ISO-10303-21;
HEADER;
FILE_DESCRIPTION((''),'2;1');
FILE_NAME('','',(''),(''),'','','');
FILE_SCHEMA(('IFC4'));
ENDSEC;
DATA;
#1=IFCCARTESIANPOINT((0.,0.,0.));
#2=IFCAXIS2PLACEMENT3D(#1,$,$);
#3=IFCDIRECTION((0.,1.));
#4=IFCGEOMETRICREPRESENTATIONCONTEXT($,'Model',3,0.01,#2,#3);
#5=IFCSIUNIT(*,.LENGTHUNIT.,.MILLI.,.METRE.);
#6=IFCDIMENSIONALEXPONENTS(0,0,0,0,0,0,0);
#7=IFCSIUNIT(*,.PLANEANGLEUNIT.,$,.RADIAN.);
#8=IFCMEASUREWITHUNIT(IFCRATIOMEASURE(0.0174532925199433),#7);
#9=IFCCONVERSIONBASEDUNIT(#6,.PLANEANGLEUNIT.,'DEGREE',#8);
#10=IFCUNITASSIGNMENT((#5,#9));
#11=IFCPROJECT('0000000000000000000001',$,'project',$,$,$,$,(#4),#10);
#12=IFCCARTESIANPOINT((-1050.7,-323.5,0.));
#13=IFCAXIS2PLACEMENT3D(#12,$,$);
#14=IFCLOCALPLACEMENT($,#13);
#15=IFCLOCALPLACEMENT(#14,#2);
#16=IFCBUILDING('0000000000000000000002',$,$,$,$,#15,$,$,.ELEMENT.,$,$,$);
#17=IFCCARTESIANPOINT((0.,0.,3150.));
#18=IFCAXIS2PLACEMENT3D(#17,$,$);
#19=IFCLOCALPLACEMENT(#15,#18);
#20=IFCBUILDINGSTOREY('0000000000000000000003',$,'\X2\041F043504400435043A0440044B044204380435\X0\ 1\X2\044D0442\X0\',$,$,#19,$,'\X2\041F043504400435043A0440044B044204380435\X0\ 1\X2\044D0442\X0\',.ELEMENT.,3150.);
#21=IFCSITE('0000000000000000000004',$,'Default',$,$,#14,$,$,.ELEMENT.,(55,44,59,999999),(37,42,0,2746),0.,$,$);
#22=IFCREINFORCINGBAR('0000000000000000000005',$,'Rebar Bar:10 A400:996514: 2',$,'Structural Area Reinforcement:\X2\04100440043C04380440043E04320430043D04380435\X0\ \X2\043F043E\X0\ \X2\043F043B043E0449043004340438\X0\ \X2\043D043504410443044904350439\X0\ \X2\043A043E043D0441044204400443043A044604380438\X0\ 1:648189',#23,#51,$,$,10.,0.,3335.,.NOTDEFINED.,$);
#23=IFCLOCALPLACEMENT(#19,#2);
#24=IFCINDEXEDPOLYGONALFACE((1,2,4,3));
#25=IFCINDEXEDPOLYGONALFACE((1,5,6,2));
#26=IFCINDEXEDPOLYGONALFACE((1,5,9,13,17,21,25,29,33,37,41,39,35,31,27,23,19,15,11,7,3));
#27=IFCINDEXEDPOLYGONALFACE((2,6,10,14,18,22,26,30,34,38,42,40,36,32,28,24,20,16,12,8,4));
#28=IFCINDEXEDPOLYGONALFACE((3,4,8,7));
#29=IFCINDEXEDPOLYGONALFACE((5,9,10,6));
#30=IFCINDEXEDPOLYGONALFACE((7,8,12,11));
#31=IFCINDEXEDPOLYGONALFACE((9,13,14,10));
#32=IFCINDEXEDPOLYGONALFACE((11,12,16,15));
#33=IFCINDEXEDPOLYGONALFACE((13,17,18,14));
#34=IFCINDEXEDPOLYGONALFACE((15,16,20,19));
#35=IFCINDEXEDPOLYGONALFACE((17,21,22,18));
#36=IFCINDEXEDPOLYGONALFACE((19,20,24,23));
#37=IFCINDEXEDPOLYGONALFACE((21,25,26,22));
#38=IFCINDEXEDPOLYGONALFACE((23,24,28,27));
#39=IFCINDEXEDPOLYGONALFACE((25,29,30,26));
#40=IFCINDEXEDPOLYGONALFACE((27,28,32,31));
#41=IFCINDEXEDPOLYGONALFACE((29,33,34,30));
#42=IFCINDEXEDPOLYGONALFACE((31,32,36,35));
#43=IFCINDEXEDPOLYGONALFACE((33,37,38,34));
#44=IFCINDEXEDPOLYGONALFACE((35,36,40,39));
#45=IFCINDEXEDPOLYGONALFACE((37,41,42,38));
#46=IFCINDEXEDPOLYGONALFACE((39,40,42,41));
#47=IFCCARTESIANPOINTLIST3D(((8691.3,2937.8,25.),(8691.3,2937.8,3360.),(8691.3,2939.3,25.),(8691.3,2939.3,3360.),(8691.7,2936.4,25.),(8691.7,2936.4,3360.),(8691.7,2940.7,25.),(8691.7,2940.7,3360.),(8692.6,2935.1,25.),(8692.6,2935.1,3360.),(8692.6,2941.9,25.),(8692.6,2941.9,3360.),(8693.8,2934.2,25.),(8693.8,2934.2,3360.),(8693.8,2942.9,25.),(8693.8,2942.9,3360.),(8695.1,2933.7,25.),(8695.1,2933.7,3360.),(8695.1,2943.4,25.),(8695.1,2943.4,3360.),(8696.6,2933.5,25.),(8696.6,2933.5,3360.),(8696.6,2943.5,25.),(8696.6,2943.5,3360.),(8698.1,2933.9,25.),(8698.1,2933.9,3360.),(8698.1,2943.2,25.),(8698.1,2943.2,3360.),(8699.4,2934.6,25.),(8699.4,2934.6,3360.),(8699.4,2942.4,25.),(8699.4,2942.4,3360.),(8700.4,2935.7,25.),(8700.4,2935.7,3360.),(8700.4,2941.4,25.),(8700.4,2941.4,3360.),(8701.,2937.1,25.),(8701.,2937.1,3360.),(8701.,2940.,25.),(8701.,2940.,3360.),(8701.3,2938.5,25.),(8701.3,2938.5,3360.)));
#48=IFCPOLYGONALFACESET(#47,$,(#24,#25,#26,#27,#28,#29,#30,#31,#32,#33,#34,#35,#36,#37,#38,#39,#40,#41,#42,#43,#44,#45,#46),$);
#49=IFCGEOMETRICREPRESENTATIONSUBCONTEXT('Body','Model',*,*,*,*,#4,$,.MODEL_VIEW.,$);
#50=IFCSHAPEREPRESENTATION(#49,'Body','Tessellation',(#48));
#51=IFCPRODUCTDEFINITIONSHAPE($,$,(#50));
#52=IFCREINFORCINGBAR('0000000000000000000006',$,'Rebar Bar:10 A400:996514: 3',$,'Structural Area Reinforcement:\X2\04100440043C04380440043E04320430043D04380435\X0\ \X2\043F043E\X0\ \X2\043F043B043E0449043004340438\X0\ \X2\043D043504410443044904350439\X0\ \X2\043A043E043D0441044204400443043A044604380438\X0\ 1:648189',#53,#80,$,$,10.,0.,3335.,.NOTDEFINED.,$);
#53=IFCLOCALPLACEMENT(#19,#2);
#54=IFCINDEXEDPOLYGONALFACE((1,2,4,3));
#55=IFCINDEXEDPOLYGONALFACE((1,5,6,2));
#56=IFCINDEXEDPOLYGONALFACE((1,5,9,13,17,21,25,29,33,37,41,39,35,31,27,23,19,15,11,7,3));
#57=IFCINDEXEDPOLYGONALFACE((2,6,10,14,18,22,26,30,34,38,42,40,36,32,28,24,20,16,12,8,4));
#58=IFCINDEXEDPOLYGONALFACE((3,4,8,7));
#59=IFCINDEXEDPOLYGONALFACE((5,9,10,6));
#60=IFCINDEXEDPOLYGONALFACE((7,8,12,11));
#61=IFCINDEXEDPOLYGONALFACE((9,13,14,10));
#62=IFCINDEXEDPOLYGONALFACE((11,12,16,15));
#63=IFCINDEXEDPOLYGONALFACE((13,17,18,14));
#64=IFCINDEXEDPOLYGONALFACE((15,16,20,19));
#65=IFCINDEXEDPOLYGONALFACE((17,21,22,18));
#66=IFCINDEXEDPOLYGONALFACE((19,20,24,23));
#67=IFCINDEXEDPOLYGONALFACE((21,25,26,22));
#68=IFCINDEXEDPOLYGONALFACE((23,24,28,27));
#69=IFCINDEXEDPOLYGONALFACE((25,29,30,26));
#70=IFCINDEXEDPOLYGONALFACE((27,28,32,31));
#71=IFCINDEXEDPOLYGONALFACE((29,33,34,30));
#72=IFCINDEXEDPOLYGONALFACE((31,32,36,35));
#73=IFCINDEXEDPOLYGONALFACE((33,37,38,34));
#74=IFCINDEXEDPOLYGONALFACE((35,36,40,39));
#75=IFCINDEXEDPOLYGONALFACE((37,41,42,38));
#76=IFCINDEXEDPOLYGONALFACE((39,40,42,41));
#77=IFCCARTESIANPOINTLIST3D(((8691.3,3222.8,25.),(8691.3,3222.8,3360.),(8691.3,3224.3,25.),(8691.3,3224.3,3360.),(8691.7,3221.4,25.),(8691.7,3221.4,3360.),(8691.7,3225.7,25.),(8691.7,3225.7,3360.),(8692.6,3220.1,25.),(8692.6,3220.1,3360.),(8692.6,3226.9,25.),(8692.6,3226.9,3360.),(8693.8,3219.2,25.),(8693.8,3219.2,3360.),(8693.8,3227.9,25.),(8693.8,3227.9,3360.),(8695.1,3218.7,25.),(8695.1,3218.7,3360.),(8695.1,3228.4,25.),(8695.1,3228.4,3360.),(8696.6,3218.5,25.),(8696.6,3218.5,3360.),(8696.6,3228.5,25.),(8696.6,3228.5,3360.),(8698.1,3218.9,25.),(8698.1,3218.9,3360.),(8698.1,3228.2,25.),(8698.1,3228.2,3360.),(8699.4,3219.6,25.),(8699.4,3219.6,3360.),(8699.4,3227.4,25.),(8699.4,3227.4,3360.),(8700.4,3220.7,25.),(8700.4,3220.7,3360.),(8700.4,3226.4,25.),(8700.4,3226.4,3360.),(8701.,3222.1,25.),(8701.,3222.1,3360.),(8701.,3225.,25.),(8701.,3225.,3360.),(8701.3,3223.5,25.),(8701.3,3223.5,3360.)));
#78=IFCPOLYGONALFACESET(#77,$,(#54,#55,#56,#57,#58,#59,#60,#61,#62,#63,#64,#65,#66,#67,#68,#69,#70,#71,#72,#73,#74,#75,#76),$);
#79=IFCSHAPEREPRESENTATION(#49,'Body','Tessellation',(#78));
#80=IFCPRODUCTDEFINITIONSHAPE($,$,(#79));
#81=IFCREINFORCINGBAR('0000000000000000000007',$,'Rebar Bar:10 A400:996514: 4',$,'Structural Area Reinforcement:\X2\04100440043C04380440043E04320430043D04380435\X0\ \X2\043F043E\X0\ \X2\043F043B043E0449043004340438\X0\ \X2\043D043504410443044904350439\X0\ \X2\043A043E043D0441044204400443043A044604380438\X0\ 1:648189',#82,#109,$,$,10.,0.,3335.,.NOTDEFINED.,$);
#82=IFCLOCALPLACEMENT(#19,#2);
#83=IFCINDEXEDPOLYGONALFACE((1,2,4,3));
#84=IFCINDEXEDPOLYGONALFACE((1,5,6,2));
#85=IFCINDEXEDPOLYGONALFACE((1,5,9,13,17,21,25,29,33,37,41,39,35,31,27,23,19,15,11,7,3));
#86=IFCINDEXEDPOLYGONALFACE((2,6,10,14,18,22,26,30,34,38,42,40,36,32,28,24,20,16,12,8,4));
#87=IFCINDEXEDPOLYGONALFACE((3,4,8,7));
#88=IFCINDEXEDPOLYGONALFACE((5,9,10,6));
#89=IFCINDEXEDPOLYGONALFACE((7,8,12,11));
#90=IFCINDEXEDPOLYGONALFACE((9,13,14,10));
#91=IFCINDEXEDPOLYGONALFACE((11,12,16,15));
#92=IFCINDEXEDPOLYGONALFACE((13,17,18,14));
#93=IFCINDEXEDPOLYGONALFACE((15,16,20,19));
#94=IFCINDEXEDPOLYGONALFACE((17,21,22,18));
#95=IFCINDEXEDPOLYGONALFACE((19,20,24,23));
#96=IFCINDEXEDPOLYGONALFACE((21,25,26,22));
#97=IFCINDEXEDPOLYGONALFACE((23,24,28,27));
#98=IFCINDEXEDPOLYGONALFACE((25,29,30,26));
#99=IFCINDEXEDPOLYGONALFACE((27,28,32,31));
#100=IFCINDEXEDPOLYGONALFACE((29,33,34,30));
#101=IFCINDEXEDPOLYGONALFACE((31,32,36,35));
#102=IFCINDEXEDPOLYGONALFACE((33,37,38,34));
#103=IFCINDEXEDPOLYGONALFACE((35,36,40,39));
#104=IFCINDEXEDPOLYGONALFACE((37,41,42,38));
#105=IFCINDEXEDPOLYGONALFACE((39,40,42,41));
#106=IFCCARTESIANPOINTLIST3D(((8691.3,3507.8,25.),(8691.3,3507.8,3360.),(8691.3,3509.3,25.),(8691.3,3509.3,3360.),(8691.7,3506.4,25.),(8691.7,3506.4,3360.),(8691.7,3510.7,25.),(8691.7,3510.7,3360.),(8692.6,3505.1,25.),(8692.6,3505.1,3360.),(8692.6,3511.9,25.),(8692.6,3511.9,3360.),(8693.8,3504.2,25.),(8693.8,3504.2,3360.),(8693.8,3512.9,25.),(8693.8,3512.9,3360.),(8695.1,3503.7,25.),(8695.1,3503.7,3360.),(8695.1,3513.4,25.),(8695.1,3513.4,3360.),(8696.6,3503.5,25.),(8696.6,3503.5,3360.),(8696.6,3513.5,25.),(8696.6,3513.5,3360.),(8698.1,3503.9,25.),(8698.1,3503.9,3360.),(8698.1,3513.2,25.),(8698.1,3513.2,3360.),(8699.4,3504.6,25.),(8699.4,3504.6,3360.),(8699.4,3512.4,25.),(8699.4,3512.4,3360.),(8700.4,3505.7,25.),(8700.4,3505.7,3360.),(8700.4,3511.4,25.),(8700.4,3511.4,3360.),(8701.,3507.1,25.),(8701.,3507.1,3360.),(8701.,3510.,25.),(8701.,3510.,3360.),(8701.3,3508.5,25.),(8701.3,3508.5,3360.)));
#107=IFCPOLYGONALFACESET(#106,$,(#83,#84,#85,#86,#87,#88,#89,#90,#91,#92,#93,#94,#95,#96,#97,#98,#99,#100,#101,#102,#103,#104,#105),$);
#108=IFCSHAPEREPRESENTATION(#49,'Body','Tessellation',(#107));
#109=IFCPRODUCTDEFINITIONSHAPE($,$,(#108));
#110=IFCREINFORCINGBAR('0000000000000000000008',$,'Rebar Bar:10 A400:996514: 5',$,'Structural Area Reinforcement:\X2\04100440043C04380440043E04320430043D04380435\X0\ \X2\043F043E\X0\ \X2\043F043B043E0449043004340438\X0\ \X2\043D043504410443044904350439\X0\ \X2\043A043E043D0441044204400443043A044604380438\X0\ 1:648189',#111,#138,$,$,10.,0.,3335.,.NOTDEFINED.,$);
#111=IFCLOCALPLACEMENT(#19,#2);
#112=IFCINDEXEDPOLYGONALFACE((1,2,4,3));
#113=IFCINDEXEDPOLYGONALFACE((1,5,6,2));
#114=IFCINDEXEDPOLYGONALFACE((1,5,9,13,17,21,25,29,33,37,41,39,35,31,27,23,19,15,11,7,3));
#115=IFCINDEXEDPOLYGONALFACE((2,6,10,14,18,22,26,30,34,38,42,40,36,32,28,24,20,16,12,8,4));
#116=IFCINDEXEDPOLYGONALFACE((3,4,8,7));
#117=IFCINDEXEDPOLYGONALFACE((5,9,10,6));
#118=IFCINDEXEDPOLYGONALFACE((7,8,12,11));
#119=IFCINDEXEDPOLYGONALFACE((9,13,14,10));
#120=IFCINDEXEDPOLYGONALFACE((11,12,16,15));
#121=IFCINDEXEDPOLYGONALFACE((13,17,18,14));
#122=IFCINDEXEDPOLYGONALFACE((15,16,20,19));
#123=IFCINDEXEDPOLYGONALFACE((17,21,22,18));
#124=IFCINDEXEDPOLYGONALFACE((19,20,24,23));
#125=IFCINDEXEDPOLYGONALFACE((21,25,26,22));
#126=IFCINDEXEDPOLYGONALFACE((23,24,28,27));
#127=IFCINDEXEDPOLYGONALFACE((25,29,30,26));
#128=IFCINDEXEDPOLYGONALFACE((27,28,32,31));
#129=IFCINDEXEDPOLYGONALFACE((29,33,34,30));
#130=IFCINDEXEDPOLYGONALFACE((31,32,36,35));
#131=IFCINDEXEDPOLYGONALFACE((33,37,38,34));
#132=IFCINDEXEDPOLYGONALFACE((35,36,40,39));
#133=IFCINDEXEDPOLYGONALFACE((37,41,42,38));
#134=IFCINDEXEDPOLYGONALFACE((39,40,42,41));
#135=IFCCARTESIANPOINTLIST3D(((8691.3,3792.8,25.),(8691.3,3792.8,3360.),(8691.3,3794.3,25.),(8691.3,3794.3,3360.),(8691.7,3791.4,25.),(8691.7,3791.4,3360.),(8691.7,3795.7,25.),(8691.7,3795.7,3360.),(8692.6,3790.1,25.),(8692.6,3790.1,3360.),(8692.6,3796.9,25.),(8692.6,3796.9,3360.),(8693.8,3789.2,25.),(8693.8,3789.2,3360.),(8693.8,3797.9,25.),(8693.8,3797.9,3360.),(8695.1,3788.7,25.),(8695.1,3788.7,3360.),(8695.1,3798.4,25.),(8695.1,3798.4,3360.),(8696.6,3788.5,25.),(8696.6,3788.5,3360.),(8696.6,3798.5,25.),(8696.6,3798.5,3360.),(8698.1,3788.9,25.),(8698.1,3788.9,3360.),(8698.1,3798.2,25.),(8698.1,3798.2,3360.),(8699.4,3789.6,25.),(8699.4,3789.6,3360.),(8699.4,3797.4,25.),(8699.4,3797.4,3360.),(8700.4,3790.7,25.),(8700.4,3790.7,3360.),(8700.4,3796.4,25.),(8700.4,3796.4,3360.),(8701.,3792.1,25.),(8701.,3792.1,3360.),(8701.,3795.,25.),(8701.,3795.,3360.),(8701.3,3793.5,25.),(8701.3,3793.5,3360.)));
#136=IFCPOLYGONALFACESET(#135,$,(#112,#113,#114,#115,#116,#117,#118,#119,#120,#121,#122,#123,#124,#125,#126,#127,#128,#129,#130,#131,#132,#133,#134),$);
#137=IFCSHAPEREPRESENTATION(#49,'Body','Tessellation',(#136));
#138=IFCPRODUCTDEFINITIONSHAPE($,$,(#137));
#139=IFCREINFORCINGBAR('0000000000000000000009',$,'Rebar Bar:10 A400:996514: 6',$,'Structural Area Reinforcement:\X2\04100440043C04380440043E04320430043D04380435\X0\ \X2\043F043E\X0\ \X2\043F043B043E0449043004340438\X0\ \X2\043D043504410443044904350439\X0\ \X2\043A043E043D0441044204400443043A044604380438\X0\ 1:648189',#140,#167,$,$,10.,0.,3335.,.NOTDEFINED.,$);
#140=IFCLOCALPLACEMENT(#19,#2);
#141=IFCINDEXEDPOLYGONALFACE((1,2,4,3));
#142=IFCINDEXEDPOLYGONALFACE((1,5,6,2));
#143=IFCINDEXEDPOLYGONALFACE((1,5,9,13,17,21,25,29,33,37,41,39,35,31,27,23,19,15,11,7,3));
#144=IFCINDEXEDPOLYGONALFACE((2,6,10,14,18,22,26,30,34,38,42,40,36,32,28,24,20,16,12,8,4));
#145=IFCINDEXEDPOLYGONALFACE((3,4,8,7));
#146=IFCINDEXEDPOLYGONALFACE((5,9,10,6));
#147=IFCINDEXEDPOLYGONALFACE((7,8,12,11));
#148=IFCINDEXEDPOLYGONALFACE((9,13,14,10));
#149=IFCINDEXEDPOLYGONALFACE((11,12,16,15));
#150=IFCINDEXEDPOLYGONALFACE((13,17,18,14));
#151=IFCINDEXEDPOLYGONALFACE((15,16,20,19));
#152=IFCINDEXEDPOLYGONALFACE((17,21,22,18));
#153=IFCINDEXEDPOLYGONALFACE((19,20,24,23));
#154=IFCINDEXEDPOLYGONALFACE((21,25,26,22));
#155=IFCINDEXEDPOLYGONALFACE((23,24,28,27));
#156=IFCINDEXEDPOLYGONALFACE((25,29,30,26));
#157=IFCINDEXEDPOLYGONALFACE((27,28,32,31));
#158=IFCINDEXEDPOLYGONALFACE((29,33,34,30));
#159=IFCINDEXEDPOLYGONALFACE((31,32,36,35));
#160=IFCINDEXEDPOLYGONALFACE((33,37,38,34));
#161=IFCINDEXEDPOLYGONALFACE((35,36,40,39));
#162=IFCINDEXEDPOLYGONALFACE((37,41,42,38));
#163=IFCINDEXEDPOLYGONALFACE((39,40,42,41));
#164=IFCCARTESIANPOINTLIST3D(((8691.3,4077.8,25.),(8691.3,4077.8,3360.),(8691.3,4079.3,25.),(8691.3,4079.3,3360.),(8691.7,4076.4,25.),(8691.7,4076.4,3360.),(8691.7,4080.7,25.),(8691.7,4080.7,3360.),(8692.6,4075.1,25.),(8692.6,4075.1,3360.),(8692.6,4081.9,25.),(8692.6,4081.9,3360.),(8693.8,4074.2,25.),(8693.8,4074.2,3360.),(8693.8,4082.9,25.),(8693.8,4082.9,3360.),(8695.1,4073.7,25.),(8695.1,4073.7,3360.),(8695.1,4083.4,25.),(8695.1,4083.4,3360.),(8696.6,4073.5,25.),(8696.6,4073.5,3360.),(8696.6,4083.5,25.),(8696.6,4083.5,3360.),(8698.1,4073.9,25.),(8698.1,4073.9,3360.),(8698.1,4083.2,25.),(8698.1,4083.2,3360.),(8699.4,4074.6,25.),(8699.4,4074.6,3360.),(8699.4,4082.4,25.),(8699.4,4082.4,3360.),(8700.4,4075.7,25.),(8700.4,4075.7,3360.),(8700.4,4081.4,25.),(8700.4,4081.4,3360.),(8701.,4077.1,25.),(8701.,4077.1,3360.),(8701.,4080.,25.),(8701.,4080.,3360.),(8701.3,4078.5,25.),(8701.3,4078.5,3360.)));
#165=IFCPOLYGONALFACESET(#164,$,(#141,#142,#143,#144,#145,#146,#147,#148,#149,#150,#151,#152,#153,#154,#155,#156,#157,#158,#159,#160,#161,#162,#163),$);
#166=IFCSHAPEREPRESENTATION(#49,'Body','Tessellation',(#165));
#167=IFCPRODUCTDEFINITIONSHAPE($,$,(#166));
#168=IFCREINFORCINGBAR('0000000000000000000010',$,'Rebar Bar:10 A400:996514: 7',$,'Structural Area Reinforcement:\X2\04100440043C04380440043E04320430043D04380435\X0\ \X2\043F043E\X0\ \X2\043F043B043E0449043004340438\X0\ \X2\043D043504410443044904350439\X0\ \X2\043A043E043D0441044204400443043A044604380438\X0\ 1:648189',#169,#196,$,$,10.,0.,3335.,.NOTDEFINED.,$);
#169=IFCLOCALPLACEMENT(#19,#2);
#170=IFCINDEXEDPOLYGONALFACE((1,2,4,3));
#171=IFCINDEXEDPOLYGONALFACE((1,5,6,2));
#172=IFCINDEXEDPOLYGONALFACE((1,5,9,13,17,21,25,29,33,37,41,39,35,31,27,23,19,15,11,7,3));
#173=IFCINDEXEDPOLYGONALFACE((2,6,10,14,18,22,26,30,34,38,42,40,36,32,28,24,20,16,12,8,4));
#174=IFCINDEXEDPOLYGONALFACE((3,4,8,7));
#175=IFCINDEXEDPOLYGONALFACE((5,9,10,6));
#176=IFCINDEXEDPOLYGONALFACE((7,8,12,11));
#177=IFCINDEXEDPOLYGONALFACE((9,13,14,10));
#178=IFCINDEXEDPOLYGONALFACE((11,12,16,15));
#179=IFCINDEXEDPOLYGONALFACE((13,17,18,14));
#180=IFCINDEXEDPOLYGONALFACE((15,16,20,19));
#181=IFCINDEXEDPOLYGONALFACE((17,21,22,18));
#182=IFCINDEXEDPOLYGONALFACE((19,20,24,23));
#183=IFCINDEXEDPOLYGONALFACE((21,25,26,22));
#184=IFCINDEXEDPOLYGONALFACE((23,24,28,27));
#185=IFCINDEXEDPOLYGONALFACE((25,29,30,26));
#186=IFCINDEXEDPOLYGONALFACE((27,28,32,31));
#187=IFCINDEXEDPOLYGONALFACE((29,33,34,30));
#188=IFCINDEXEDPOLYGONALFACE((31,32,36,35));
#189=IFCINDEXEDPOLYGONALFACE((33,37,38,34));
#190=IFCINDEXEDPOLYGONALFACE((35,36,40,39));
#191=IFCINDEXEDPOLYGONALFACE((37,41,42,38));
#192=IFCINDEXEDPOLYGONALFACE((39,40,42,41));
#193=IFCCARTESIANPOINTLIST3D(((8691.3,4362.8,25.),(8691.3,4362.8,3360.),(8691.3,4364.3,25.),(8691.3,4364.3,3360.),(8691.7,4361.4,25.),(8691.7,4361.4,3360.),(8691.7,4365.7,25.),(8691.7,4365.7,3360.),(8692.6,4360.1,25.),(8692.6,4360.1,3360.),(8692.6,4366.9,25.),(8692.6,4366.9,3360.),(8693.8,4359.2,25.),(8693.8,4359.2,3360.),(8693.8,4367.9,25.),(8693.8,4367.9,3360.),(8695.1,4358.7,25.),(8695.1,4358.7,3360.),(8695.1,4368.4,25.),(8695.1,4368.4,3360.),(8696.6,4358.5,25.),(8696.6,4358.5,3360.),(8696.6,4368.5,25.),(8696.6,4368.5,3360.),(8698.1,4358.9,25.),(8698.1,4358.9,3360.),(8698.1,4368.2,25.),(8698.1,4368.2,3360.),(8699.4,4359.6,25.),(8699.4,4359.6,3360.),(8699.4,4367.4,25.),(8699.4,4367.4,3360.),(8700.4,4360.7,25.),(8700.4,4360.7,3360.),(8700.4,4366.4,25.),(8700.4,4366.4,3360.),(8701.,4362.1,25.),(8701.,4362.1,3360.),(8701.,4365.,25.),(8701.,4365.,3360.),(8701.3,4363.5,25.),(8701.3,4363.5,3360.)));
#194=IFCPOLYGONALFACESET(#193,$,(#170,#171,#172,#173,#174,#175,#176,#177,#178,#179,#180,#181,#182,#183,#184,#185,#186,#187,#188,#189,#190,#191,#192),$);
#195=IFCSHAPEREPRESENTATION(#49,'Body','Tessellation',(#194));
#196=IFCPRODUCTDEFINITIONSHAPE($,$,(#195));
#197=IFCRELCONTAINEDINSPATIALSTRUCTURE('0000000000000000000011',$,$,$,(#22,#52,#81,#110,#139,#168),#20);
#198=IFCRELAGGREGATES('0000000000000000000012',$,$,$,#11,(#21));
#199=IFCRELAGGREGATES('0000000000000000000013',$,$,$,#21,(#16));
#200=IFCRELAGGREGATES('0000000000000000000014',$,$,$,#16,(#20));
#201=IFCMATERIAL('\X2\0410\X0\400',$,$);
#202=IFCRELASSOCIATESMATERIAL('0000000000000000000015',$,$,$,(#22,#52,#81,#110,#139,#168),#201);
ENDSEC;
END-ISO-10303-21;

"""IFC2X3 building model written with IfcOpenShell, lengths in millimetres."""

from ifc_helpers import new_model, entity, si_unit, converted_unit, direction, frame, origin, place, context, subcontext, project, spatial, material, element, save


model = new_model("IFC2X3")

# Units and contexts
model_context = context("Model", 3, precision=0.01, world=origin(), true_north=direction((0.0, 1.0)))
body_context = subcontext(model_context, "Body", "Model", "MODEL_VIEW")
ifc_project = project(units=[si_unit("LENGTHUNIT", "METRE", prefix="MILLI"), converted_unit("PLANEANGLEUNIT", "DEGREE", entity("IfcRatioMeasure", 0.0174532925199433), si_unit("PLANEANGLEUNIT", "RADIAN"), dimensions=[0, 0, 0, 0, 0, 0, 0])], contexts=[model_context])

# Site, building, storey
site_placement = place(None, frame((-1050.7, -323.5, 0.0)))
site = spatial("IfcSite", under=ifc_project, at=site_placement, Name="Default", CompositionType="ELEMENT", RefLatitude=(55, 44, 59, 999999), RefLongitude=(37, 42, 0, 2746), RefElevation=0.0)
building_placement = place(site_placement, origin())
building = spatial("IfcBuilding", under=site, at=building_placement, CompositionType="ELEMENT")
storey_placement = place(building_placement, frame((0.0, 0.0, 3150.0)))
storey = spatial("IfcBuildingStorey", under=building, at=storey_placement, Name="Перекрытие 1эт", LongName="Перекрытие 1эт", CompositionType="ELEMENT", Elevation=3150.0)

# Reinforcing bars
ifc_material = material(Name="А400")
reinforcing_bar_1_placement = place(storey_placement, origin())
element("IfcReinforcingBar", 1, at=reinforcing_bar_1_placement, inside=storey, material=ifc_material, Name="Rebar Bar:10 A400:996514: 2", ObjectType="Structural Area Reinforcement:Армирование по площади несущей конструкции 1:648189", BarLength=3335.0, BarRole="NOTDEFINED", CrossSectionArea=0.0, NominalDiameter=10.0, context=body_context, shape_type="AdvancedSweptSolid", body=[
    entity("IfcSweptDiskSolid", entity("IfcCompositeCurve", [entity("IfcCompositeCurveSegment", "CONTINUOUS", True, entity("IfcPolyline", [entity("IfcCartesianPoint", [8696.3, 2938.5, 25.0]), entity("IfcCartesianPoint", [8696.3, 2938.5, 3360.0])]))], False), 5.0, None, 0.0, 1.0),
])
reinforcing_bar_2_placement = place(storey_placement, origin())
element("IfcReinforcingBar", 2, at=reinforcing_bar_2_placement, inside=storey, material=ifc_material, Name="Rebar Bar:10 A400:996514: 3", ObjectType="Structural Area Reinforcement:Армирование по площади несущей конструкции 1:648189", BarLength=3335.0, BarRole="NOTDEFINED", CrossSectionArea=0.0, NominalDiameter=10.0, context=body_context, shape_type="AdvancedSweptSolid", body=[
    entity("IfcSweptDiskSolid", entity("IfcCompositeCurve", [entity("IfcCompositeCurveSegment", "CONTINUOUS", True, entity("IfcPolyline", [entity("IfcCartesianPoint", [8696.3, 3223.5, 25.0]), entity("IfcCartesianPoint", [8696.3, 3223.5, 3360.0])]))], False), 5.0, None, 0.0, 1.0),
])
reinforcing_bar_3_placement = place(storey_placement, origin())
element("IfcReinforcingBar", 3, at=reinforcing_bar_3_placement, inside=storey, material=ifc_material, Name="Rebar Bar:10 A400:996514: 4", ObjectType="Structural Area Reinforcement:Армирование по площади несущей конструкции 1:648189", BarLength=3335.0, BarRole="NOTDEFINED", CrossSectionArea=0.0, NominalDiameter=10.0, context=body_context, shape_type="AdvancedSweptSolid", body=[
    entity("IfcSweptDiskSolid", entity("IfcCompositeCurve", [entity("IfcCompositeCurveSegment", "CONTINUOUS", True, entity("IfcPolyline", [entity("IfcCartesianPoint", [8696.3, 3508.5, 25.0]), entity("IfcCartesianPoint", [8696.3, 3508.5, 3360.0])]))], False), 5.0, None, 0.0, 1.0),
])
reinforcing_bar_4_placement = place(storey_placement, origin())
element("IfcReinforcingBar", 4, at=reinforcing_bar_4_placement, inside=storey, material=ifc_material, Name="Rebar Bar:10 A400:996514: 5", ObjectType="Structural Area Reinforcement:Армирование по площади несущей конструкции 1:648189", BarLength=3335.0, BarRole="NOTDEFINED", CrossSectionArea=0.0, NominalDiameter=10.0, context=body_context, shape_type="AdvancedSweptSolid", body=[
    entity("IfcSweptDiskSolid", entity("IfcCompositeCurve", [entity("IfcCompositeCurveSegment", "CONTINUOUS", True, entity("IfcPolyline", [entity("IfcCartesianPoint", [8696.3, 3793.5, 25.0]), entity("IfcCartesianPoint", [8696.3, 3793.5, 3360.0])]))], False), 5.0, None, 0.0, 1.0),
])
reinforcing_bar_5_placement = place(storey_placement, origin())
element("IfcReinforcingBar", 5, at=reinforcing_bar_5_placement, inside=storey, material=ifc_material, Name="Rebar Bar:10 A400:996514: 6", ObjectType="Structural Area Reinforcement:Армирование по площади несущей конструкции 1:648189", BarLength=3335.0, BarRole="NOTDEFINED", CrossSectionArea=0.0, NominalDiameter=10.0, context=body_context, shape_type="AdvancedSweptSolid", body=[
    entity("IfcSweptDiskSolid", entity("IfcCompositeCurve", [entity("IfcCompositeCurveSegment", "CONTINUOUS", True, entity("IfcPolyline", [entity("IfcCartesianPoint", [8696.3, 4078.5, 25.0]), entity("IfcCartesianPoint", [8696.3, 4078.5, 3360.0])]))], False), 5.0, None, 0.0, 1.0),
])
reinforcing_bar_6_placement = place(storey_placement, origin())
element("IfcReinforcingBar", 6, at=reinforcing_bar_6_placement, inside=storey, material=ifc_material, Name="Rebar Bar:10 A400:996514: 7", ObjectType="Structural Area Reinforcement:Армирование по площади несущей конструкции 1:648189", BarLength=3335.0, BarRole="NOTDEFINED", CrossSectionArea=0.0, NominalDiameter=10.0, context=body_context, shape_type="AdvancedSweptSolid", body=[
    entity("IfcSweptDiskSolid", entity("IfcCompositeCurve", [entity("IfcCompositeCurveSegment", "CONTINUOUS", True, entity("IfcPolyline", [entity("IfcCartesianPoint", [8696.3, 4363.5, 25.0]), entity("IfcCartesianPoint", [8696.3, 4363.5, 3360.0])]))], False), 5.0, None, 0.0, 1.0),
])

save(model, "model.ifc")
